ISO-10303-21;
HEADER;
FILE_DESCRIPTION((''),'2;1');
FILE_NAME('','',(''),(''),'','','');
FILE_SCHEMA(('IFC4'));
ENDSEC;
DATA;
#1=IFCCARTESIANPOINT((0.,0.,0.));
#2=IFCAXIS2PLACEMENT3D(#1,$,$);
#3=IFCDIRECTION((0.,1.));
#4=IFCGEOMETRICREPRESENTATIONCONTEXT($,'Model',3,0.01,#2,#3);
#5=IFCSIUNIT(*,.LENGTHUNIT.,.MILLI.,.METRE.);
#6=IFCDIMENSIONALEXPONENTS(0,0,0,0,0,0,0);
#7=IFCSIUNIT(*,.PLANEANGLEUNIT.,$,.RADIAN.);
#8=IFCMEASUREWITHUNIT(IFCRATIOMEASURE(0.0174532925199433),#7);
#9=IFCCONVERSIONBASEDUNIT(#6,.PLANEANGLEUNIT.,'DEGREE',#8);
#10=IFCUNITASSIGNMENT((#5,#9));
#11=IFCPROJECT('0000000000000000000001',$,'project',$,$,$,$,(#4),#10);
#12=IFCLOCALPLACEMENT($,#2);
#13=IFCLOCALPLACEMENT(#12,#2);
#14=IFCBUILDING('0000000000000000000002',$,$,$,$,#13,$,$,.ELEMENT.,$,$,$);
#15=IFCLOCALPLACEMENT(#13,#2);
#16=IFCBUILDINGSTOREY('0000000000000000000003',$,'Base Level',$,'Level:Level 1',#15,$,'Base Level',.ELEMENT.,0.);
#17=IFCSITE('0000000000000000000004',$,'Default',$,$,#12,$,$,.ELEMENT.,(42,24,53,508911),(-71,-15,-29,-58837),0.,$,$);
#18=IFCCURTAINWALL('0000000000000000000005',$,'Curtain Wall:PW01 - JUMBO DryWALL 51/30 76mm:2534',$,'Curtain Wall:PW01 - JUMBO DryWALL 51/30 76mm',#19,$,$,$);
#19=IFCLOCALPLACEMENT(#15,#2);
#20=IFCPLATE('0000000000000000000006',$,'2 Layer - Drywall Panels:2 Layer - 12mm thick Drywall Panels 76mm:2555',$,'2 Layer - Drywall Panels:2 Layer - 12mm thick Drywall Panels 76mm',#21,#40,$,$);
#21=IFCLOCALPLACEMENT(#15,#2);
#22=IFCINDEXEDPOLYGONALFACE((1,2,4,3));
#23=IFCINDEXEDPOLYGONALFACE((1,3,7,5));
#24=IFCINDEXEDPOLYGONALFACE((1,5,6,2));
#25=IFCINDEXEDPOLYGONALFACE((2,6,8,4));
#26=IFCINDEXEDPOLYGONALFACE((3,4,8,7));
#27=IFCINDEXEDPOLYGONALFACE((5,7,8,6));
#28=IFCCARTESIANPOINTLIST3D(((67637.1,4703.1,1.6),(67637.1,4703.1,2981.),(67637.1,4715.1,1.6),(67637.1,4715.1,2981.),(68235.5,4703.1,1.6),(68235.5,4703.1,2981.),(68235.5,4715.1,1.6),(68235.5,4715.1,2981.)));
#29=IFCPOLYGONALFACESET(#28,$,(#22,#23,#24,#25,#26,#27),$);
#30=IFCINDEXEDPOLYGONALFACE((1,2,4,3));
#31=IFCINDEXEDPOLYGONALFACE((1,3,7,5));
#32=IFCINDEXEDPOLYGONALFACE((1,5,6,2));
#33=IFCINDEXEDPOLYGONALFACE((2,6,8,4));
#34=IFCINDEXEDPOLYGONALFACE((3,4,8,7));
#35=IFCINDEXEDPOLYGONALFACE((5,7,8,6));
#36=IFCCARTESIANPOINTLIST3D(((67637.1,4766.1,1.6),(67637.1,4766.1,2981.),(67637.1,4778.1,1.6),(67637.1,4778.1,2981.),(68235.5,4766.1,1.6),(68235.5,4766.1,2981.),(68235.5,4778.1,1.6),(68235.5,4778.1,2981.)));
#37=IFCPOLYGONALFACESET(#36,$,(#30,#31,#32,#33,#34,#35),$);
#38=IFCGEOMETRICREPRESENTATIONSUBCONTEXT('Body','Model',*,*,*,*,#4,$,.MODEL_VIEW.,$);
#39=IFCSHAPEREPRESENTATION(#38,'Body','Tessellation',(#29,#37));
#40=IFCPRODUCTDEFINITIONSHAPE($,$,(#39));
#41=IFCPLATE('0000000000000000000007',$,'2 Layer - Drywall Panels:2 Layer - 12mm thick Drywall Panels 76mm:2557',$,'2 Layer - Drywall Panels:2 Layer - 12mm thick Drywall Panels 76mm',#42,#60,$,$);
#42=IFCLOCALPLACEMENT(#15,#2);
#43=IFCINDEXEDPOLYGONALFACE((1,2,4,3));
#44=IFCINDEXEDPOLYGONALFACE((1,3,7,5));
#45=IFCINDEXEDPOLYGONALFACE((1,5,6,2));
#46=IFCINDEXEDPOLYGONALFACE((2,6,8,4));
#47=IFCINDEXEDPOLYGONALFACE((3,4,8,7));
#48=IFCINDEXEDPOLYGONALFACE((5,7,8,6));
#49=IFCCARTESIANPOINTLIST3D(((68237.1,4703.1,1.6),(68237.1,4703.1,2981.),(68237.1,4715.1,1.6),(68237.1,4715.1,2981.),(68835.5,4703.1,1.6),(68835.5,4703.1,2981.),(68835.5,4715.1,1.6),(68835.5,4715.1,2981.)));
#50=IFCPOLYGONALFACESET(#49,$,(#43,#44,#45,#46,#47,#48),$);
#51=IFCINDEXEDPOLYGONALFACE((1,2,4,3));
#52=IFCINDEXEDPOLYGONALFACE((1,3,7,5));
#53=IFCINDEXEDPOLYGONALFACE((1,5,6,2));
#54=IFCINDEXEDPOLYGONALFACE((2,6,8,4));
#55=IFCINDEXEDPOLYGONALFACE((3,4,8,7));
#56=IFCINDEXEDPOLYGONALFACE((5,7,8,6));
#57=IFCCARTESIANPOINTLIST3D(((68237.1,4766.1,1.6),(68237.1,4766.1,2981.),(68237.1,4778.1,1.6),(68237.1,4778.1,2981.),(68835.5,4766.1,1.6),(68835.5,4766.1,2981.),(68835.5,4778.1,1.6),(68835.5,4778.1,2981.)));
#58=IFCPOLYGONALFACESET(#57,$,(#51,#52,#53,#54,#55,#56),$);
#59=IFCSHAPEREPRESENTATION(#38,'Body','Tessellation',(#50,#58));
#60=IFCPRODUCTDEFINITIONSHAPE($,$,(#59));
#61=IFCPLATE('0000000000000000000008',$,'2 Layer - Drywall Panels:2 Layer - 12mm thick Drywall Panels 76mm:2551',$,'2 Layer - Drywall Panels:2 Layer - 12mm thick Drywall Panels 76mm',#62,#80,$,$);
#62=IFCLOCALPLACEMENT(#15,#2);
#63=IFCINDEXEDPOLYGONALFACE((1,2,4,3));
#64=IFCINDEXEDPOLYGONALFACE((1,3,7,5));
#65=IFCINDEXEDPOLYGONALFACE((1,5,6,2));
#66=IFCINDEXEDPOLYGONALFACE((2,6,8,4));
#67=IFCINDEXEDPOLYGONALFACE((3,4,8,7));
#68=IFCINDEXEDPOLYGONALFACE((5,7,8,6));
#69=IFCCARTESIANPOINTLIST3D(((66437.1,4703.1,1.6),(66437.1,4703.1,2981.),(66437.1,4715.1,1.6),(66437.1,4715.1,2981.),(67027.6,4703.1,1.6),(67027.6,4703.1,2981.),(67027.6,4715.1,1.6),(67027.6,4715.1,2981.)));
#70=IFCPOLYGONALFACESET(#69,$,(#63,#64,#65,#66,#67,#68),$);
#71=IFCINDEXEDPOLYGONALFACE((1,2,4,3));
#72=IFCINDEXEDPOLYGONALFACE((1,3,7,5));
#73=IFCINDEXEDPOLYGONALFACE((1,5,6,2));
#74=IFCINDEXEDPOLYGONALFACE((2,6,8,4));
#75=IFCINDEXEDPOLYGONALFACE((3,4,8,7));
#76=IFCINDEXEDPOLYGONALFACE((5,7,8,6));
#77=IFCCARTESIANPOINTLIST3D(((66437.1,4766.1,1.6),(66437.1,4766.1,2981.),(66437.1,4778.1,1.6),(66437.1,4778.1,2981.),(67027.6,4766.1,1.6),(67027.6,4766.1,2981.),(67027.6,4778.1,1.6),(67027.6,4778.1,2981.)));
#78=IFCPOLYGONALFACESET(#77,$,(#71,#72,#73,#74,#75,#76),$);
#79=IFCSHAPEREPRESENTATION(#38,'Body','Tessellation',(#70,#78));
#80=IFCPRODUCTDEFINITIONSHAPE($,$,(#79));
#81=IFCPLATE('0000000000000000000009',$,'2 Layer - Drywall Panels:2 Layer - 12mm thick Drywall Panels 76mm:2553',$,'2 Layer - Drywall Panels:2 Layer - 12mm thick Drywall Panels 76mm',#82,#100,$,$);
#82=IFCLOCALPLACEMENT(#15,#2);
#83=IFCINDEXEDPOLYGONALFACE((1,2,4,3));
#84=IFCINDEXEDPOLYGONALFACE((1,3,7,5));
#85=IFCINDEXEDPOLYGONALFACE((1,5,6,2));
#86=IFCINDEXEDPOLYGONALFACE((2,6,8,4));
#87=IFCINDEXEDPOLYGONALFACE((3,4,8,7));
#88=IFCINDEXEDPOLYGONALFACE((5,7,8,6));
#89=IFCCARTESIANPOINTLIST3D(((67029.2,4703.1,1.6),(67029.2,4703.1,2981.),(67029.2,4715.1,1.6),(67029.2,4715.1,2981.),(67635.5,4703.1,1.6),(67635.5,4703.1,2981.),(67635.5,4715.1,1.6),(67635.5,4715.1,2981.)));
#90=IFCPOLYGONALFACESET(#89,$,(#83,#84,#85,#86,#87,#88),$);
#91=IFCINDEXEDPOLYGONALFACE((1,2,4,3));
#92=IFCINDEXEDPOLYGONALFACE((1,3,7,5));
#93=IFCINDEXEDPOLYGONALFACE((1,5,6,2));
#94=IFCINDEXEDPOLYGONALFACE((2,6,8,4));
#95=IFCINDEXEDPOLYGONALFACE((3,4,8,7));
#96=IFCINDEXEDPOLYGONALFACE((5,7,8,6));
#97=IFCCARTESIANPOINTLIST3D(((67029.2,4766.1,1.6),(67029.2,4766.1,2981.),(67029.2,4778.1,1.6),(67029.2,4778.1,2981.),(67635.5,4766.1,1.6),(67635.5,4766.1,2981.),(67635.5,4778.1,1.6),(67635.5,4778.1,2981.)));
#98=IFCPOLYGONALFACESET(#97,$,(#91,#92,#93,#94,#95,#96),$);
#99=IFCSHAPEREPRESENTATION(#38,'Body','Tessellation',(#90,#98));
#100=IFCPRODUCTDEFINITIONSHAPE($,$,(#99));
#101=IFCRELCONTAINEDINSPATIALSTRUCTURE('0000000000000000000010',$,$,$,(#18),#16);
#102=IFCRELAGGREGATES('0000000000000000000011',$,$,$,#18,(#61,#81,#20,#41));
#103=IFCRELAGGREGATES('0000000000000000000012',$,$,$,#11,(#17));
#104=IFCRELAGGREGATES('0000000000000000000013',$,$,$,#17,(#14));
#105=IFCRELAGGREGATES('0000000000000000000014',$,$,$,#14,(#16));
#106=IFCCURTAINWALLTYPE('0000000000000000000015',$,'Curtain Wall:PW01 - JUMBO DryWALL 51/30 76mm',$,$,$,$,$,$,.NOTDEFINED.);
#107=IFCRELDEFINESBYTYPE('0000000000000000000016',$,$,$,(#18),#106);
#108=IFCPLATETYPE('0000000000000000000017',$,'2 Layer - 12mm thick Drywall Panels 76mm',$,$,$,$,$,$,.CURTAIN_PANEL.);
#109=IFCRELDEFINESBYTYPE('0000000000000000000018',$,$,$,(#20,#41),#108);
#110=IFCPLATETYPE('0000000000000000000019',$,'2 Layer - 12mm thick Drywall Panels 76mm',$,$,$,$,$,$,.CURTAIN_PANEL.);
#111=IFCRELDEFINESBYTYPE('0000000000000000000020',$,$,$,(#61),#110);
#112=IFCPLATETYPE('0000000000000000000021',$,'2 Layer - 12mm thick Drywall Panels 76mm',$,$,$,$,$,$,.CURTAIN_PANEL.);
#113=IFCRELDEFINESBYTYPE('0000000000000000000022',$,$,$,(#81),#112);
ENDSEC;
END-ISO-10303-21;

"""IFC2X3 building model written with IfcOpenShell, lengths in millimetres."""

from ifc_helpers import new_model, entity, si_unit, converted_unit, direction, frame, frame_2d, origin, origin_2d_with_axis, place, context, subcontext, project, spatial, rectangle, extrude, source, transform, mapped, type_object, type_shapes, element, aggregate, save


model = new_model("IFC2X3")

# Units and contexts
model_context = context("Model", 3, precision=0.01, world=origin(), true_north=direction((0.0, 1.0)))
body_context = subcontext(model_context, "Body", "Model", "MODEL_VIEW")
ifc_project = project(units=[si_unit("LENGTHUNIT", "METRE", prefix="MILLI"), converted_unit("PLANEANGLEUNIT", "DEGREE", entity("IfcRatioMeasure", 0.0174532925199433), si_unit("PLANEANGLEUNIT", "RADIAN"), dimensions=[0, 0, 0, 0, 0, 0, 0])], contexts=[model_context])

# Site, building, storey
site_placement = place(None, origin())
site = spatial("IfcSite", under=ifc_project, at=site_placement, Name="Default", CompositionType="ELEMENT", RefLatitude=(42, 24, 53, 508911), RefLongitude=(-71, -15, -29, -58837), RefElevation=0.0)
building_placement = place(site_placement, origin())
building = spatial("IfcBuilding", under=site, at=building_placement, CompositionType="ELEMENT")
storey_placement = place(building_placement, origin())
storey = spatial("IfcBuildingStorey", under=building, at=storey_placement, Name="Base Level", ObjectType="Level:Level 1", LongName="Base Level", CompositionType="ELEMENT", Elevation=0.0)

# Curtain wall, plates
curtain_wall_type = type_object("IfcCurtainWallType", Name="Curtain Wall:PW01 - JUMBO DryWALL 51/30 76mm", PredefinedType="NOTDEFINED")
curtain_wall_placement = place(building_placement, origin())
curtain_wall = element("IfcCurtainWall", 1, at=curtain_wall_placement, inside=storey, type_object=curtain_wall_type, Name="Curtain Wall:PW01 - JUMBO DryWALL 51/30 76mm:2534", ObjectType="Curtain Wall:PW01 - JUMBO DryWALL 51/30 76mm")
plate_type_1 = type_object("IfcPlateType", Name="2 Layer - 12mm thick Drywall Panels 76mm", PredefinedType="CURTAIN_PANEL")
shared_shape_1 = source(origin(), body_context, "Body", "SweptSolid", [
    extrude(rectangle(XDim=598.4, YDim=12.0, at=origin_2d_with_axis()), frame((0.0, -31.5, 0.0), z_axis=(0.0, 0.0, 1.0), x_axis=(-1.0, 0.0, 0.0)), (0.0, 0.0, 1.0), 2979.4),
    extrude(rectangle(XDim=12.0, YDim=598.4, at=frame_2d((0.0, 0.0), x_axis=(1.0, 0.0))), frame((0.0, 31.5, 0.0), z_axis=(0.0, 0.0, 1.0), x_axis=(0.0, 1.0, 0.0)), (0.0, 0.0, 1.0), 2979.4),
])
type_shapes(plate_type_1, [shared_shape_1])
plate_1_placement = place(curtain_wall_placement, frame((67936.3, 4740.6, 1.6)))
plate_1 = element("IfcPlate", 2, at=plate_1_placement, type_object=plate_type_1, Name="2 Layer - Drywall Panels:2 Layer - 12mm thick Drywall Panels 76mm:2555", ObjectType="2 Layer - Drywall Panels:2 Layer - 12mm thick Drywall Panels 76mm", context=body_context, shape_type="MappedRepresentation", body=[
    mapped(shared_shape_1, transform((0.0, 0.0, 0.0), scale=1.0)),
])
plate_2_placement = place(curtain_wall_placement, frame((68536.3, 4740.6, 1.6)))
plate_2 = element("IfcPlate", 3, at=plate_2_placement, type_object=plate_type_1, Name="2 Layer - Drywall Panels:2 Layer - 12mm thick Drywall Panels 76mm:2557", ObjectType="2 Layer - Drywall Panels:2 Layer - 12mm thick Drywall Panels 76mm", context=body_context, shape_type="MappedRepresentation", body=[
    mapped(shared_shape_1, transform((0.0, 0.0, 0.0), scale=1.0)),
])
plate_type_2 = type_object("IfcPlateType", Name="2 Layer - 12mm thick Drywall Panels 76mm", PredefinedType="CURTAIN_PANEL")
shared_shape_2 = source(origin(), body_context, "Body", "SweptSolid", [
    extrude(rectangle(XDim=590.5, YDim=12.0, at=origin_2d_with_axis()), frame((0.0, -31.5, 0.0), z_axis=(0.0, 0.0, 1.0), x_axis=(-1.0, 0.0, 0.0)), (0.0, 0.0, 1.0), 2979.4),
    extrude(rectangle(XDim=12.0, YDim=590.5, at=frame_2d((0.0, 0.0), x_axis=(1.0, 0.0))), frame((0.0, 31.5, 0.0), z_axis=(0.0, 0.0, 1.0), x_axis=(0.0, 1.0, 0.0)), (0.0, 0.0, 1.0), 2979.4),
])
type_shapes(plate_type_2, [shared_shape_2])
plate_3_placement = place(curtain_wall_placement, frame((66732.4, 4740.6, 1.6)))
plate_3 = element("IfcPlate", 4, at=plate_3_placement, type_object=plate_type_2, Name="2 Layer - Drywall Panels:2 Layer - 12mm thick Drywall Panels 76mm:2551", ObjectType="2 Layer - Drywall Panels:2 Layer - 12mm thick Drywall Panels 76mm", context=body_context, shape_type="MappedRepresentation", body=[
    mapped(shared_shape_2, transform((0.0, 0.0, 0.0), scale=1.0)),
])
plate_type_3 = type_object("IfcPlateType", Name="2 Layer - 12mm thick Drywall Panels 76mm", PredefinedType="CURTAIN_PANEL")
shared_shape_3 = source(origin(), body_context, "Body", "SweptSolid", [
    extrude(rectangle(XDim=606.3, YDim=12.0, at=origin_2d_with_axis()), frame((0.0, -31.5, 0.0), z_axis=(0.0, 0.0, 1.0), x_axis=(-1.0, 0.0, 0.0)), (0.0, 0.0, 1.0), 2979.4),
    extrude(rectangle(XDim=12.0, YDim=606.3, at=frame_2d((0.0, 0.0), x_axis=(1.0, 0.0))), frame((0.0, 31.5, 0.0), z_axis=(0.0, 0.0, 1.0), x_axis=(0.0, 1.0, 0.0)), (0.0, 0.0, 1.0), 2979.4),
])
type_shapes(plate_type_3, [shared_shape_3])
plate_4_placement = place(curtain_wall_placement, frame((67332.4, 4740.6, 1.6)))
plate_4 = element("IfcPlate", 5, at=plate_4_placement, type_object=plate_type_3, Name="2 Layer - Drywall Panels:2 Layer - 12mm thick Drywall Panels 76mm:2553", ObjectType="2 Layer - Drywall Panels:2 Layer - 12mm thick Drywall Panels 76mm", context=body_context, shape_type="MappedRepresentation", body=[
    mapped(shared_shape_3, transform((0.0, 0.0, 0.0), scale=1.0)),
])
aggregate(curtain_wall, [plate_3, plate_4, plate_1, plate_2])

save(model, "model.ifc")
